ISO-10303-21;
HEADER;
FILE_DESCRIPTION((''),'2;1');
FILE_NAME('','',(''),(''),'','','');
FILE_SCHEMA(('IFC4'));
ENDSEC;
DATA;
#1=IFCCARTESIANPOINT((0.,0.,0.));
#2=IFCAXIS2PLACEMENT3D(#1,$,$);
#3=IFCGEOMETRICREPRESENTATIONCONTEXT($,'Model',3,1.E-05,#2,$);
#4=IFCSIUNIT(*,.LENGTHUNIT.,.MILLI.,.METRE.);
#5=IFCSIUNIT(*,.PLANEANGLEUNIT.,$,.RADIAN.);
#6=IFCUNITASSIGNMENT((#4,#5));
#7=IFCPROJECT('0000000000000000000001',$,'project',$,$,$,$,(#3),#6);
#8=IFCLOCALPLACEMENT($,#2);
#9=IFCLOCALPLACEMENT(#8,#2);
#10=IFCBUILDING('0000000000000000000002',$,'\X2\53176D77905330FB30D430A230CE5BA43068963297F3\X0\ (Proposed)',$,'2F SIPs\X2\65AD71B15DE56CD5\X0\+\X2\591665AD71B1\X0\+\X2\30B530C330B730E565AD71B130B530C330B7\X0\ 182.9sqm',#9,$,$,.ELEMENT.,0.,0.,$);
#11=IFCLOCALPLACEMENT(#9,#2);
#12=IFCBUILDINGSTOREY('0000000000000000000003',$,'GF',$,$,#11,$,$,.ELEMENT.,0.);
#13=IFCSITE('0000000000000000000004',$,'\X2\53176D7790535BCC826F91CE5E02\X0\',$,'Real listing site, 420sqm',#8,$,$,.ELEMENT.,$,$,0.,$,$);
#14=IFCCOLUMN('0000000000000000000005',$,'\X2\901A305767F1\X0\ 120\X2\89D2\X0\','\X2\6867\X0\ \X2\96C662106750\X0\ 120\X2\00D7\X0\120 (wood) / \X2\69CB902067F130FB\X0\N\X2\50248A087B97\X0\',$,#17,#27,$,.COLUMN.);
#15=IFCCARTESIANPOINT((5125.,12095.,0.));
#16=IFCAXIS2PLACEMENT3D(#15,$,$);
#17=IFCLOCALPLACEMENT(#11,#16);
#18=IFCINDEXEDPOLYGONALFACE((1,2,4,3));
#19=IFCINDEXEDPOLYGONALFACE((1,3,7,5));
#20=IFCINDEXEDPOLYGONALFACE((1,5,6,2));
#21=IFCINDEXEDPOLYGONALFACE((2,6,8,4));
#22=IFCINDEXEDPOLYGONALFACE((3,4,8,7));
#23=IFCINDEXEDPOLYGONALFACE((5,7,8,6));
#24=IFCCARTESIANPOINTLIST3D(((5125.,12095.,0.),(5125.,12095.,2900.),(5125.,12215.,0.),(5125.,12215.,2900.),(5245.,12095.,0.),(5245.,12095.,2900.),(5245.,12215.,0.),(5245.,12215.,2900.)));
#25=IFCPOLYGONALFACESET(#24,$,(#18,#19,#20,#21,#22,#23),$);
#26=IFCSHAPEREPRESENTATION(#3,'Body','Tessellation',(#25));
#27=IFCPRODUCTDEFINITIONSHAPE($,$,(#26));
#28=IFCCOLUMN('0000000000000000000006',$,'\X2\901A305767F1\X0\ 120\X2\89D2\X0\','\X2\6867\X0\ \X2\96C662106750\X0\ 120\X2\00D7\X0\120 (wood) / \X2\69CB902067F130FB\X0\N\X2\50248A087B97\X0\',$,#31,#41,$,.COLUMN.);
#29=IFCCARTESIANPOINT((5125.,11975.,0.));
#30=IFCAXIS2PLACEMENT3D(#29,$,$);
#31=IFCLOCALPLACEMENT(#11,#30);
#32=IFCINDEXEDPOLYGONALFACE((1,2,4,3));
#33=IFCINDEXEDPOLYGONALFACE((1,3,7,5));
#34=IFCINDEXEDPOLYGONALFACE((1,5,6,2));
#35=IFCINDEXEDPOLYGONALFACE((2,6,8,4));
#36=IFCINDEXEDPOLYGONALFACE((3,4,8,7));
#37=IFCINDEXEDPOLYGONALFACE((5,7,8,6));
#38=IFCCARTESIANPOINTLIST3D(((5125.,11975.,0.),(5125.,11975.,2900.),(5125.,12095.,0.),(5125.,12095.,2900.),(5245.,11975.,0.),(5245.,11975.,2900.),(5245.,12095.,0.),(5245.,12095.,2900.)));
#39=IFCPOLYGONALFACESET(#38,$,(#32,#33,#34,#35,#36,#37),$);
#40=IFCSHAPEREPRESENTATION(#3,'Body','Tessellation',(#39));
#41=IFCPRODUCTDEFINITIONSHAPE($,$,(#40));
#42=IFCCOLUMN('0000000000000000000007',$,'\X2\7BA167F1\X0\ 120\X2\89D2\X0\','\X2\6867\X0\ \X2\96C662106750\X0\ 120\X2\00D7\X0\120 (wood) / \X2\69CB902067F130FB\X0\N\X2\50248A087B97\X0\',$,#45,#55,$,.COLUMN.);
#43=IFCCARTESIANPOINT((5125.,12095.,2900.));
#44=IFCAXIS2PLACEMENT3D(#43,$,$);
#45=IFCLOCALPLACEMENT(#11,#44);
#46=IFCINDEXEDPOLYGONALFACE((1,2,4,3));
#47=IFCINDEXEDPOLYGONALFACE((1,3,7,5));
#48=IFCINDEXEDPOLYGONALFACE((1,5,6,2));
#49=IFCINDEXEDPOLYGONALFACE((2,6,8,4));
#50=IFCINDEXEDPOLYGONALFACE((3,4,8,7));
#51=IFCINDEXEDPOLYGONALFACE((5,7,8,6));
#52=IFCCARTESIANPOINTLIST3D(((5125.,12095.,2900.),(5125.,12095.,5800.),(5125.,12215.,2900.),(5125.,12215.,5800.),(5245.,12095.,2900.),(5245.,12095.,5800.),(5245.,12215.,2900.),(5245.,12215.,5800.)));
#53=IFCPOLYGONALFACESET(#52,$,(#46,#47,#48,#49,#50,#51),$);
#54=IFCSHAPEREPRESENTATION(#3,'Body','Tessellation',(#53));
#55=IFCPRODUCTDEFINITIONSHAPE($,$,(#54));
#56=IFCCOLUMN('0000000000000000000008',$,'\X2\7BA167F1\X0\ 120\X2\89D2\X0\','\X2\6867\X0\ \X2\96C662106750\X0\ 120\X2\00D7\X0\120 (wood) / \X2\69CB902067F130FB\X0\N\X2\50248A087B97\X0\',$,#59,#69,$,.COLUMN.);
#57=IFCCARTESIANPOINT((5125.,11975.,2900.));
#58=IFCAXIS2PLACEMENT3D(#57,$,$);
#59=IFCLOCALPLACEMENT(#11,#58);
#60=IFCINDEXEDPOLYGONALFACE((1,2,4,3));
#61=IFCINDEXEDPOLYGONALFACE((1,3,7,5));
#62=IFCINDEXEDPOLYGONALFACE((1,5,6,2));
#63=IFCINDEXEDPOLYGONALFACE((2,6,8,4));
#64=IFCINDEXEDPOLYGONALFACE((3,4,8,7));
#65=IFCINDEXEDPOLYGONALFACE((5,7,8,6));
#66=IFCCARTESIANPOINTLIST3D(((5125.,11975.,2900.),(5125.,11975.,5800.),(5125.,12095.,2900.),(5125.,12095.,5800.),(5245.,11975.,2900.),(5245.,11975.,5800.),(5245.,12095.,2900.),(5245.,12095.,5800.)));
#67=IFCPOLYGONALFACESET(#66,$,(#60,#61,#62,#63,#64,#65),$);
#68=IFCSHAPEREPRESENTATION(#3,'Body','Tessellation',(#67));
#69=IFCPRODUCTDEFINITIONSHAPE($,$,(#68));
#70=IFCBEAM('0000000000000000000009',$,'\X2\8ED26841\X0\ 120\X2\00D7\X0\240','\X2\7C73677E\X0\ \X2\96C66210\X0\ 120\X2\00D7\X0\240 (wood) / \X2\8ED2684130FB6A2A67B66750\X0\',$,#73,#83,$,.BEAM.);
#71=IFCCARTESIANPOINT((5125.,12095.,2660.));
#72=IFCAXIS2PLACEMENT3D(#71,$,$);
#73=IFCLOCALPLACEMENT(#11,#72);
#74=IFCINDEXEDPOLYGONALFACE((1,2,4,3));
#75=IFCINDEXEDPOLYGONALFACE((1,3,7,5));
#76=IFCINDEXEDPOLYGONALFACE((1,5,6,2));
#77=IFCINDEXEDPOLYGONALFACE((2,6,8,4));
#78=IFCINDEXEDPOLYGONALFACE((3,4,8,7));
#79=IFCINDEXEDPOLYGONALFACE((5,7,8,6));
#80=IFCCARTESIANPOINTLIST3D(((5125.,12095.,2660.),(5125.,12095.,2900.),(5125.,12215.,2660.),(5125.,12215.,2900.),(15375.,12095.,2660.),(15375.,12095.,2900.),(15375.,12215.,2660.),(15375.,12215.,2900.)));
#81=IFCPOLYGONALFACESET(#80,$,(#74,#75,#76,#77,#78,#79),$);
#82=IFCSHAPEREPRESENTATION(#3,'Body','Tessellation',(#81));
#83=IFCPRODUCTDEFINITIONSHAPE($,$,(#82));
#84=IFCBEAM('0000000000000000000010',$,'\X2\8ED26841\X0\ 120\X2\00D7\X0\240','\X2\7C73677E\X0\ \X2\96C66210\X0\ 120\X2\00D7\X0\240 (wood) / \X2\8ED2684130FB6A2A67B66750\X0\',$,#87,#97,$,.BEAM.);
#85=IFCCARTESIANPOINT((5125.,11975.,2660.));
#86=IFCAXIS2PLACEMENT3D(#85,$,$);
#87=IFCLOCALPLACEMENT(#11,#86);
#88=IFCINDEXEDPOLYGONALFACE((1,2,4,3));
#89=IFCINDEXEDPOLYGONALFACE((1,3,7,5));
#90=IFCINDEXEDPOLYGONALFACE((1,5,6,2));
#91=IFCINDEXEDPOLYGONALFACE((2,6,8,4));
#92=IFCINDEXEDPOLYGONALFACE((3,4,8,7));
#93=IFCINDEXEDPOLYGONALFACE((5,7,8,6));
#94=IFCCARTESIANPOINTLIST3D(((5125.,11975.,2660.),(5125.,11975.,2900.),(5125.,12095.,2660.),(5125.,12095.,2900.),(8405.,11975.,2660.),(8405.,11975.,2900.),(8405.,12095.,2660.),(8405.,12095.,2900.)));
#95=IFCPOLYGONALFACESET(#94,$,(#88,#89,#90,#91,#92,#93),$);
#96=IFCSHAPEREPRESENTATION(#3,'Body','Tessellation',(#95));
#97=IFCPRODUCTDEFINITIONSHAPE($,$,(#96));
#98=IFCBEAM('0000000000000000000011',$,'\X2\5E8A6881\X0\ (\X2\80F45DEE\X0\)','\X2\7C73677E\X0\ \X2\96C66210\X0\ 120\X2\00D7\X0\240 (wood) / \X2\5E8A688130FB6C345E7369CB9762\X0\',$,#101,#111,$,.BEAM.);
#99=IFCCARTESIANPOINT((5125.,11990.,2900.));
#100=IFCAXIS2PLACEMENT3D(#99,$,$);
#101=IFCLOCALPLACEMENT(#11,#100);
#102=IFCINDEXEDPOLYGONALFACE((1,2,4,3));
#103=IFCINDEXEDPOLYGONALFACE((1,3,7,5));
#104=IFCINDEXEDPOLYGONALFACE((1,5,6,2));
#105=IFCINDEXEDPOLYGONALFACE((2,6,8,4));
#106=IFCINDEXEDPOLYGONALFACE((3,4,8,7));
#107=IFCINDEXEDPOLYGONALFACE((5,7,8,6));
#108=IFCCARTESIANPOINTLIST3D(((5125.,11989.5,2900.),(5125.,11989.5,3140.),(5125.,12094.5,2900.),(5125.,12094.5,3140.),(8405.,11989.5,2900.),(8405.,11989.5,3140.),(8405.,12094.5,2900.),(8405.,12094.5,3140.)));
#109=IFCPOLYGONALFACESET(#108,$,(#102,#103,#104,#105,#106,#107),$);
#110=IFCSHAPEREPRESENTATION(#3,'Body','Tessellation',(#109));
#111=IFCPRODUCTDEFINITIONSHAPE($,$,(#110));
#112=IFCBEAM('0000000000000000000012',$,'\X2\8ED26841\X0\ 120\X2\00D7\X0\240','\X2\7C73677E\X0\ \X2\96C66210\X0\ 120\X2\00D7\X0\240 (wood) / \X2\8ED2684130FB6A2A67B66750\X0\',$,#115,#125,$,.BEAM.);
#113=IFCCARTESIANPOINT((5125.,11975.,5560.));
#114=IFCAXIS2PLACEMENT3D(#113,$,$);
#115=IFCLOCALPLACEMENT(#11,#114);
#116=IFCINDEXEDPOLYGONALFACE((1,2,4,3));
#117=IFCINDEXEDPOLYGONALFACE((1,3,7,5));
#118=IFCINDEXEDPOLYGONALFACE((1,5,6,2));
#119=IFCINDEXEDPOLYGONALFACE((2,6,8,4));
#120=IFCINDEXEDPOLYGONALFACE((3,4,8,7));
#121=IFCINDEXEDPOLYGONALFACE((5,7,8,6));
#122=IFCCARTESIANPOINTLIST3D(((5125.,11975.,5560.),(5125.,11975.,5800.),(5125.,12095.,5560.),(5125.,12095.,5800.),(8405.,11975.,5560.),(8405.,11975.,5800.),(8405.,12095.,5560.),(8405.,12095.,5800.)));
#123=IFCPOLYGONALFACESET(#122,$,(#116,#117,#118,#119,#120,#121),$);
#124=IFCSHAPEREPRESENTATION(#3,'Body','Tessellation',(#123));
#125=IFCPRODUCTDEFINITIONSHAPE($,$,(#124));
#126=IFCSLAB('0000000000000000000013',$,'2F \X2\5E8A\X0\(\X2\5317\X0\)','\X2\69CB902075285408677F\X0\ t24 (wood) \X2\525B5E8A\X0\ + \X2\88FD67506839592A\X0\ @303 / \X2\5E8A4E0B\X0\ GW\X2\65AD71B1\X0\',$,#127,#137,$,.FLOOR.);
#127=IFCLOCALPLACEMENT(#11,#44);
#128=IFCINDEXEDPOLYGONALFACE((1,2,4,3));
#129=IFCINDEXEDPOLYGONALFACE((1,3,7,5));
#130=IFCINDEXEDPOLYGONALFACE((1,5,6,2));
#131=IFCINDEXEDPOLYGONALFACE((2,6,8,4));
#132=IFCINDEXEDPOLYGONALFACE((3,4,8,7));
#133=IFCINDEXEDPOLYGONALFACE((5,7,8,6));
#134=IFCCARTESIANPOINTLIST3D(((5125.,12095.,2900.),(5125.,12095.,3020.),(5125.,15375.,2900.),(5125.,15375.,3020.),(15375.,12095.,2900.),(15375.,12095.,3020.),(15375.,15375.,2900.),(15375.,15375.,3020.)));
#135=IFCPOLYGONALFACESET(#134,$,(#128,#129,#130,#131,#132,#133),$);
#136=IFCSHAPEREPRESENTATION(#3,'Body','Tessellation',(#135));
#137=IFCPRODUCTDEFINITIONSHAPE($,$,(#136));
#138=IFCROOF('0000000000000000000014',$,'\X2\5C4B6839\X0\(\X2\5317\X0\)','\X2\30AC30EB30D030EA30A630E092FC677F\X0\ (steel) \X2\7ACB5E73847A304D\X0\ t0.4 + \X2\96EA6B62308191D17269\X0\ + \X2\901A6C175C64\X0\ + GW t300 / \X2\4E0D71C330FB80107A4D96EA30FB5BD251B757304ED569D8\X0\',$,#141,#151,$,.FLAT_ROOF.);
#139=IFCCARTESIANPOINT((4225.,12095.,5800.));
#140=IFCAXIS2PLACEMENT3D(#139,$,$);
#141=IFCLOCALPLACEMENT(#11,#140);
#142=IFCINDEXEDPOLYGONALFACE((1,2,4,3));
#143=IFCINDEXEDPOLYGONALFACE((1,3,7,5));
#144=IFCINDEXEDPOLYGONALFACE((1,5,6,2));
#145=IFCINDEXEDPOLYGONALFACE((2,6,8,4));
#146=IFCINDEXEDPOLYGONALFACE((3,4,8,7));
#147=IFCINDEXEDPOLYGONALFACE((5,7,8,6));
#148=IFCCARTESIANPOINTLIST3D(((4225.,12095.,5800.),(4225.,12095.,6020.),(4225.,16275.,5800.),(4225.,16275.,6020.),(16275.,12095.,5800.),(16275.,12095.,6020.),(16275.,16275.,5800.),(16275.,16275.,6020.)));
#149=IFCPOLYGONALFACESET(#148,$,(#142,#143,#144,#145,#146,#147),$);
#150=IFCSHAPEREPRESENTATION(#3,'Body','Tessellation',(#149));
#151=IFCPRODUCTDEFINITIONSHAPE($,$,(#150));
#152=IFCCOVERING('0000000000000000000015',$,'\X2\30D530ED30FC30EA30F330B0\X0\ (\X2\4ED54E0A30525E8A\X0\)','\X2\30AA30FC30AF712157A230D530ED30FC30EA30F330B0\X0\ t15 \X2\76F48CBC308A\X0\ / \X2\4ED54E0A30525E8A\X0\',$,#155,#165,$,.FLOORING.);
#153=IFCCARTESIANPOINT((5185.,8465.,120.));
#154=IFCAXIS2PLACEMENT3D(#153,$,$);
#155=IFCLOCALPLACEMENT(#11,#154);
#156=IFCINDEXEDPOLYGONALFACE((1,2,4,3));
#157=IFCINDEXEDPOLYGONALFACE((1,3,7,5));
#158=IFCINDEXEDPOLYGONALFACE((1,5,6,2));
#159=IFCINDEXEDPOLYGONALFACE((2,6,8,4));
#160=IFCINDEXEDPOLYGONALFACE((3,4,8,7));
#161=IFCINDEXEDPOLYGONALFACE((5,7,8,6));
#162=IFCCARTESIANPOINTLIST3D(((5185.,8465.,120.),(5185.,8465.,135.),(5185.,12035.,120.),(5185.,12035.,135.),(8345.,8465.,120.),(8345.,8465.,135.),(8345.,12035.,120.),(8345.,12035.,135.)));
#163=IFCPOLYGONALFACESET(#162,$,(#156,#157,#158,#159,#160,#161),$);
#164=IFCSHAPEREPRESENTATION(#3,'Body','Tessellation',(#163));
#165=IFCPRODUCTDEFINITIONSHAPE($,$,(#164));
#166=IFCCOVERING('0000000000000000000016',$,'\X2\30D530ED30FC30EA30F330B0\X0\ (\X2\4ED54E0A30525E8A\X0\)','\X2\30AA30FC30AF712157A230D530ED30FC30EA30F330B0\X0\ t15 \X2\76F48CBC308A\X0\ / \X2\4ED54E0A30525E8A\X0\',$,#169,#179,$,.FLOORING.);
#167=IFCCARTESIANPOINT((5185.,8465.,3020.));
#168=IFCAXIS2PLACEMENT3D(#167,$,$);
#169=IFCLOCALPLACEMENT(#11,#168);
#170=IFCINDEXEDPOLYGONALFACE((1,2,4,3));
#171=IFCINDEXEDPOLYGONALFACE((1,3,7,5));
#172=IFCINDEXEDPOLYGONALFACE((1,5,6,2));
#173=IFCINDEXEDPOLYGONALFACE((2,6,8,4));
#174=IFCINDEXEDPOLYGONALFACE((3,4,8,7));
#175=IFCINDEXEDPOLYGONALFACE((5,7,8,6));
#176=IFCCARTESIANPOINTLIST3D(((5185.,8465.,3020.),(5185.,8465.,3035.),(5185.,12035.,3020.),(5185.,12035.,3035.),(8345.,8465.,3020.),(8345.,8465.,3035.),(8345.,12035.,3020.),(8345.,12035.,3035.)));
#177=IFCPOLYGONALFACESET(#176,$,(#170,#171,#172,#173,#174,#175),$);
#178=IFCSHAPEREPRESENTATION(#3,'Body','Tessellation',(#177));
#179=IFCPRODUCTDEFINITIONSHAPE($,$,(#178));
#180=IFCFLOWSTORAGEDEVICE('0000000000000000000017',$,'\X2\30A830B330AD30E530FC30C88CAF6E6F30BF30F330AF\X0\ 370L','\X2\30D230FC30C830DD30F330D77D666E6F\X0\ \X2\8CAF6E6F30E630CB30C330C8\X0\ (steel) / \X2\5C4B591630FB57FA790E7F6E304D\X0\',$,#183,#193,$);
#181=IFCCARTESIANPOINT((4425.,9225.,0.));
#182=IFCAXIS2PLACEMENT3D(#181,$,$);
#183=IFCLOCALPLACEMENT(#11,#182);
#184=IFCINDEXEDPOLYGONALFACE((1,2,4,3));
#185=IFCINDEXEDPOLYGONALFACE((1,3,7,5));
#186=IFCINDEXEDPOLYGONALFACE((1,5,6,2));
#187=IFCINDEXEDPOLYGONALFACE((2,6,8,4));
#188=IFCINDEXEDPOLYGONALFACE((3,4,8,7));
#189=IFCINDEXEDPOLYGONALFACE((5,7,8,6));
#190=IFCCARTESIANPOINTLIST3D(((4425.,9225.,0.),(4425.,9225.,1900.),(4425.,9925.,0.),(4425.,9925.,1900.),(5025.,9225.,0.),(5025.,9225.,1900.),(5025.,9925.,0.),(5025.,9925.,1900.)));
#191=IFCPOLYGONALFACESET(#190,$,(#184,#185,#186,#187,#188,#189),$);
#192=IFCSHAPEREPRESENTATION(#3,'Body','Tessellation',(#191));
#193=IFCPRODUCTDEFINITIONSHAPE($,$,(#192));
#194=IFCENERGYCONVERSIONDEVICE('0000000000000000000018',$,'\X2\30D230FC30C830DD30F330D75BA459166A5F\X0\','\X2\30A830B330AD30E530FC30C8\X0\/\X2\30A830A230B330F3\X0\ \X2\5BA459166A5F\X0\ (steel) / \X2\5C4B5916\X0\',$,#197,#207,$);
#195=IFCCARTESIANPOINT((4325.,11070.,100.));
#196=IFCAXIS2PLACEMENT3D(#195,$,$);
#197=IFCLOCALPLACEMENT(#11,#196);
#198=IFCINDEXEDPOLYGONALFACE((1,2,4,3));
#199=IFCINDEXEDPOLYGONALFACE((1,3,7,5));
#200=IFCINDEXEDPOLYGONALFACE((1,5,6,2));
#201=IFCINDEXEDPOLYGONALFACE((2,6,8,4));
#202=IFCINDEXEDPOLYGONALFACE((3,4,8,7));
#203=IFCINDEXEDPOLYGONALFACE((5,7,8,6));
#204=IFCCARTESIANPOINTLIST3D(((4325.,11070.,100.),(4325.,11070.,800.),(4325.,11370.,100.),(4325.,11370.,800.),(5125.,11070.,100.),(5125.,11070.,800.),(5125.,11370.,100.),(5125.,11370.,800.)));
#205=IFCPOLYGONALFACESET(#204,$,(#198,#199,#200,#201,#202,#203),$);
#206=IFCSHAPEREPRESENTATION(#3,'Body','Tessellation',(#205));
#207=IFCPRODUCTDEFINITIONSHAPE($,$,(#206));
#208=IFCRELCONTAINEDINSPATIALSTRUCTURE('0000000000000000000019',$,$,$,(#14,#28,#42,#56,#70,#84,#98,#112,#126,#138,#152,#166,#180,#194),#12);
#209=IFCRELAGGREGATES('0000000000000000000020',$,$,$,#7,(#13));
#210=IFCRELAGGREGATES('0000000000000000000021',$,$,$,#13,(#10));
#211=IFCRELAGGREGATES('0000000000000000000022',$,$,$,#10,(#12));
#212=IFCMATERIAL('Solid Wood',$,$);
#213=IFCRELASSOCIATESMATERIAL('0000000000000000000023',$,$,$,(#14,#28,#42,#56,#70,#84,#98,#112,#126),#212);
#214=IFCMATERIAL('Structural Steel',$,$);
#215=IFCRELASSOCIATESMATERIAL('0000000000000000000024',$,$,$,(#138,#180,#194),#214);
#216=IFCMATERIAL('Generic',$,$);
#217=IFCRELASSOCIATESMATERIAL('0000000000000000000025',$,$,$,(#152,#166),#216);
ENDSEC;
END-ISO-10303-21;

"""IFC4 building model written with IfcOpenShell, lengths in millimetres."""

from ifc_helpers import new_model, si_unit, frame, frame_2d, origin, place, context, project, spatial, rectangle, extrude, material, element, save


model = new_model("IFC4")

# Units and contexts
model_context = context("Model", 3, precision=1e-05, world=origin())
ifc_project = project(units=[si_unit("LENGTHUNIT", "METRE", prefix="MILLI"), si_unit("PLANEANGLEUNIT", "RADIAN")], contexts=[model_context])

# Site, building, storey
site_placement = place(None, origin())
site = spatial("IfcSite", under=ifc_project, at=site_placement, Name="北海道富良野市", ObjectType="Real listing site, 420sqm", CompositionType="ELEMENT", RefElevation=0.0)
building_placement = place(site_placement, origin())
building = spatial("IfcBuilding", under=site, at=building_placement, Name="北海道・ピアノ室と防音 (Proposed)", ObjectType="2F SIPs断熱工法+外断熱+サッシュ断熱サッシ 182.9sqm", CompositionType="ELEMENT", ElevationOfRefHeight=0.0, ElevationOfTerrain=0.0)
storey_placement = place(building_placement, origin())
storey = spatial("IfcBuildingStorey", under=building, at=storey_placement, Name="GF", CompositionType="ELEMENT", Elevation=0.0)

# Columns
ifc_material_1 = material(Name="Solid Wood")
column_1_placement = place(storey_placement, frame((5125.0, 12095.0, 0.0)))
element("IfcColumn", 1, at=column_1_placement, inside=storey, material=ifc_material_1, Name="通し柱 120角", Description="桧 集成材 120×120 (wood) / 構造柱・N値計算", PredefinedType="COLUMN", context=model_context, shape_type="SweptSolid", body=[
    extrude(rectangle(XDim=120.0, YDim=120.0, at=frame_2d((60.0, 60.0))), frame((5125.0, 12095.0, 0.0)), (0.0, 0.0, 1.0), 2900.0),
])
column_2_placement = place(storey_placement, frame((5125.0, 11975.0, 0.0)))
element("IfcColumn", 2, at=column_2_placement, inside=storey, material=ifc_material_1, Name="通し柱 120角", Description="桧 集成材 120×120 (wood) / 構造柱・N値計算", PredefinedType="COLUMN", context=model_context, shape_type="SweptSolid", body=[
    extrude(rectangle(XDim=120.0, YDim=120.0, at=frame_2d((60.0, 60.0))), frame((5125.0, 11975.0, 0.0)), (0.0, 0.0, 1.0), 2900.0),
])
column_3_placement = place(storey_placement, frame((5125.0, 12095.0, 2900.0)))
element("IfcColumn", 3, at=column_3_placement, inside=storey, material=ifc_material_1, Name="管柱 120角", Description="桧 集成材 120×120 (wood) / 構造柱・N値計算", PredefinedType="COLUMN", context=model_context, shape_type="SweptSolid", body=[
    extrude(rectangle(XDim=120.0, YDim=120.0, at=frame_2d((60.0, 60.0))), frame((5125.0, 12095.0, 2900.0)), (0.0, 0.0, 1.0), 2900.0),
])
column_4_placement = place(storey_placement, frame((5125.0, 11975.0, 2900.0)))
element("IfcColumn", 4, at=column_4_placement, inside=storey, material=ifc_material_1, Name="管柱 120角", Description="桧 集成材 120×120 (wood) / 構造柱・N値計算", PredefinedType="COLUMN", context=model_context, shape_type="SweptSolid", body=[
    extrude(rectangle(XDim=120.0, YDim=120.0, at=frame_2d((60.0, 60.0))), frame((5125.0, 11975.0, 2900.0)), (0.0, 0.0, 1.0), 2900.0),
])

# Beams
beam_1_placement = place(storey_placement, frame((5125.0, 12095.0, 2660.0)))
element("IfcBeam", 5, at=beam_1_placement, inside=storey, material=ifc_material_1, Name="軒桁 120×240", Description="米松 集成 120×240 (wood) / 軒桁・横架材", PredefinedType="BEAM", context=model_context, shape_type="SweptSolid", body=[
    extrude(rectangle(XDim=10250.0, YDim=120.0, at=frame_2d((5125.0, 60.0))), frame((5125.0, 12095.0, 2660.0)), (0.0, 0.0, 1.0), 240.0),
])
beam_2_placement = place(storey_placement, frame((5125.0, 11975.0, 2660.0)))
element("IfcBeam", 6, at=beam_2_placement, inside=storey, material=ifc_material_1, Name="軒桁 120×240", Description="米松 集成 120×240 (wood) / 軒桁・横架材", PredefinedType="BEAM", context=model_context, shape_type="SweptSolid", body=[
    extrude(rectangle(XDim=3280.0, YDim=120.0, at=frame_2d((1640.0, 60.0))), frame((5125.0, 11975.0, 2660.0)), (0.0, 0.0, 1.0), 240.0),
])
beam_3_placement = place(storey_placement, frame((5125.0, 11990.0, 2900.0)))
element("IfcBeam", 7, at=beam_3_placement, inside=storey, material=ifc_material_1, Name="床梁 (胴差)", Description="米松 集成 120×240 (wood) / 床梁・水平構面", PredefinedType="BEAM", context=model_context, shape_type="SweptSolid", body=[
    extrude(rectangle(XDim=3280.0, YDim=105.0, at=frame_2d((1640.0, 52.0))), frame((5125.0, 11990.0, 2900.0)), (0.0, 0.0, 1.0), 240.0),
])
beam_4_placement = place(storey_placement, frame((5125.0, 11975.0, 5560.0)))
element("IfcBeam", 8, at=beam_4_placement, inside=storey, material=ifc_material_1, Name="軒桁 120×240", Description="米松 集成 120×240 (wood) / 軒桁・横架材", PredefinedType="BEAM", context=model_context, shape_type="SweptSolid", body=[
    extrude(rectangle(XDim=3280.0, YDim=120.0, at=frame_2d((1640.0, 60.0))), frame((5125.0, 11975.0, 5560.0)), (0.0, 0.0, 1.0), 240.0),
])

# Slab
slab_1_placement = place(storey_placement, frame((5125.0, 12095.0, 2900.0)))
element("IfcSlab", 9, at=slab_1_placement, inside=storey, material=ifc_material_1, Name="2F 床(北)", Description="構造用合板 t24 (wood) 剛床 + 製材根太 @303 / 床下 GW断熱", PredefinedType="FLOOR", context=model_context, shape_type="SweptSolid", body=[
    extrude(rectangle(XDim=10250.0, YDim=3280.0, at=frame_2d((5125.0, 1640.0))), frame((5125.0, 12095.0, 2900.0)), (0.0, 0.0, 1.0), 120.0),
])

# Roof
ifc_material_2 = material(Name="Structural Steel")
for number, where, name in (
    (10, (4225.0, 12095.0, 5800.0), "屋根(北)"),
):
    element("IfcRoof", number, at=place(storey_placement, frame(where)), inside=storey, material=ifc_material_2, Name=name, Description="ガルバリウム鋼板 (steel) 立平葺き t0.4 + 雪止め金物 + 通気層 + GW t300 / 不燃・耐積雪・寒冷地仕様", PredefinedType="FLAT_ROOF", context=model_context, shape_type="SweptSolid", body=[
        extrude(rectangle(XDim=12050.0, YDim=4180.0, at=frame_2d((6025.0, 2090.0))), frame((4225.0, 12095.0, 5800.0)), (0.0, 0.0, 1.0), 220.0),
    ])

# Coverings
ifc_material_3 = material(Name="Generic")
covering_1_placement = place(storey_placement, frame((5185.0, 8465.0, 120.0)))
element("IfcCovering", 11, at=covering_1_placement, inside=storey, material=ifc_material_3, Name="フローリング (仕上げ床)", Description="オーク無垢フローリング t15 直貼り / 仕上げ床", PredefinedType="FLOORING", context=model_context, shape_type="SweptSolid", body=[
    extrude(rectangle(XDim=3160.0, YDim=3570.0, at=frame_2d((1580.0, 1785.0))), frame((5185.0, 8465.0, 120.0)), (0.0, 0.0, 1.0), 15.0),
])
covering_2_placement = place(storey_placement, frame((5185.0, 8465.0, 3020.0)))
element("IfcCovering", 12, at=covering_2_placement, inside=storey, material=ifc_material_3, Name="フローリング (仕上げ床)", Description="オーク無垢フローリング t15 直貼り / 仕上げ床", PredefinedType="FLOORING", context=model_context, shape_type="SweptSolid", body=[
    extrude(rectangle(XDim=3160.0, YDim=3570.0, at=frame_2d((1580.0, 1785.0))), frame((5185.0, 8465.0, 3020.0)), (0.0, 0.0, 1.0), 15.0),
])

# Flow storage device
flow_storage_device_placement = place(storey_placement, frame((4425.0, 9225.0, 0.0)))
element("IfcFlowStorageDevice", 13, at=flow_storage_device_placement, inside=storey, material=ifc_material_2, Name="エコキュート貯湯タンク 370L", Description="ヒートポンプ給湯 貯湯ユニット (steel) / 屋外・基礎置き", context=model_context, shape_type="SweptSolid", body=[
    extrude(rectangle(XDim=600.0, YDim=700.0, at=frame_2d((300.0, 350.0))), frame((4425.0, 9225.0, 0.0)), (0.0, 0.0, 1.0), 1900.0),
])

# Energy conversion device
energy_conversion_device_placement = place(storey_placement, frame((4325.0, 11070.0, 100.0)))
element("IfcEnergyConversionDevice", 14, at=energy_conversion_device_placement, inside=storey, material=ifc_material_2, Name="ヒートポンプ室外機", Description="エコキュート/エアコン 室外機 (steel) / 屋外", context=model_context, shape_type="SweptSolid", body=[
    extrude(rectangle(XDim=800.0, YDim=300.0, at=frame_2d((400.0, 150.0))), frame((4325.0, 11070.0, 100.0)), (0.0, 0.0, 1.0), 700.0),
])

save(model, "model.ifc")
